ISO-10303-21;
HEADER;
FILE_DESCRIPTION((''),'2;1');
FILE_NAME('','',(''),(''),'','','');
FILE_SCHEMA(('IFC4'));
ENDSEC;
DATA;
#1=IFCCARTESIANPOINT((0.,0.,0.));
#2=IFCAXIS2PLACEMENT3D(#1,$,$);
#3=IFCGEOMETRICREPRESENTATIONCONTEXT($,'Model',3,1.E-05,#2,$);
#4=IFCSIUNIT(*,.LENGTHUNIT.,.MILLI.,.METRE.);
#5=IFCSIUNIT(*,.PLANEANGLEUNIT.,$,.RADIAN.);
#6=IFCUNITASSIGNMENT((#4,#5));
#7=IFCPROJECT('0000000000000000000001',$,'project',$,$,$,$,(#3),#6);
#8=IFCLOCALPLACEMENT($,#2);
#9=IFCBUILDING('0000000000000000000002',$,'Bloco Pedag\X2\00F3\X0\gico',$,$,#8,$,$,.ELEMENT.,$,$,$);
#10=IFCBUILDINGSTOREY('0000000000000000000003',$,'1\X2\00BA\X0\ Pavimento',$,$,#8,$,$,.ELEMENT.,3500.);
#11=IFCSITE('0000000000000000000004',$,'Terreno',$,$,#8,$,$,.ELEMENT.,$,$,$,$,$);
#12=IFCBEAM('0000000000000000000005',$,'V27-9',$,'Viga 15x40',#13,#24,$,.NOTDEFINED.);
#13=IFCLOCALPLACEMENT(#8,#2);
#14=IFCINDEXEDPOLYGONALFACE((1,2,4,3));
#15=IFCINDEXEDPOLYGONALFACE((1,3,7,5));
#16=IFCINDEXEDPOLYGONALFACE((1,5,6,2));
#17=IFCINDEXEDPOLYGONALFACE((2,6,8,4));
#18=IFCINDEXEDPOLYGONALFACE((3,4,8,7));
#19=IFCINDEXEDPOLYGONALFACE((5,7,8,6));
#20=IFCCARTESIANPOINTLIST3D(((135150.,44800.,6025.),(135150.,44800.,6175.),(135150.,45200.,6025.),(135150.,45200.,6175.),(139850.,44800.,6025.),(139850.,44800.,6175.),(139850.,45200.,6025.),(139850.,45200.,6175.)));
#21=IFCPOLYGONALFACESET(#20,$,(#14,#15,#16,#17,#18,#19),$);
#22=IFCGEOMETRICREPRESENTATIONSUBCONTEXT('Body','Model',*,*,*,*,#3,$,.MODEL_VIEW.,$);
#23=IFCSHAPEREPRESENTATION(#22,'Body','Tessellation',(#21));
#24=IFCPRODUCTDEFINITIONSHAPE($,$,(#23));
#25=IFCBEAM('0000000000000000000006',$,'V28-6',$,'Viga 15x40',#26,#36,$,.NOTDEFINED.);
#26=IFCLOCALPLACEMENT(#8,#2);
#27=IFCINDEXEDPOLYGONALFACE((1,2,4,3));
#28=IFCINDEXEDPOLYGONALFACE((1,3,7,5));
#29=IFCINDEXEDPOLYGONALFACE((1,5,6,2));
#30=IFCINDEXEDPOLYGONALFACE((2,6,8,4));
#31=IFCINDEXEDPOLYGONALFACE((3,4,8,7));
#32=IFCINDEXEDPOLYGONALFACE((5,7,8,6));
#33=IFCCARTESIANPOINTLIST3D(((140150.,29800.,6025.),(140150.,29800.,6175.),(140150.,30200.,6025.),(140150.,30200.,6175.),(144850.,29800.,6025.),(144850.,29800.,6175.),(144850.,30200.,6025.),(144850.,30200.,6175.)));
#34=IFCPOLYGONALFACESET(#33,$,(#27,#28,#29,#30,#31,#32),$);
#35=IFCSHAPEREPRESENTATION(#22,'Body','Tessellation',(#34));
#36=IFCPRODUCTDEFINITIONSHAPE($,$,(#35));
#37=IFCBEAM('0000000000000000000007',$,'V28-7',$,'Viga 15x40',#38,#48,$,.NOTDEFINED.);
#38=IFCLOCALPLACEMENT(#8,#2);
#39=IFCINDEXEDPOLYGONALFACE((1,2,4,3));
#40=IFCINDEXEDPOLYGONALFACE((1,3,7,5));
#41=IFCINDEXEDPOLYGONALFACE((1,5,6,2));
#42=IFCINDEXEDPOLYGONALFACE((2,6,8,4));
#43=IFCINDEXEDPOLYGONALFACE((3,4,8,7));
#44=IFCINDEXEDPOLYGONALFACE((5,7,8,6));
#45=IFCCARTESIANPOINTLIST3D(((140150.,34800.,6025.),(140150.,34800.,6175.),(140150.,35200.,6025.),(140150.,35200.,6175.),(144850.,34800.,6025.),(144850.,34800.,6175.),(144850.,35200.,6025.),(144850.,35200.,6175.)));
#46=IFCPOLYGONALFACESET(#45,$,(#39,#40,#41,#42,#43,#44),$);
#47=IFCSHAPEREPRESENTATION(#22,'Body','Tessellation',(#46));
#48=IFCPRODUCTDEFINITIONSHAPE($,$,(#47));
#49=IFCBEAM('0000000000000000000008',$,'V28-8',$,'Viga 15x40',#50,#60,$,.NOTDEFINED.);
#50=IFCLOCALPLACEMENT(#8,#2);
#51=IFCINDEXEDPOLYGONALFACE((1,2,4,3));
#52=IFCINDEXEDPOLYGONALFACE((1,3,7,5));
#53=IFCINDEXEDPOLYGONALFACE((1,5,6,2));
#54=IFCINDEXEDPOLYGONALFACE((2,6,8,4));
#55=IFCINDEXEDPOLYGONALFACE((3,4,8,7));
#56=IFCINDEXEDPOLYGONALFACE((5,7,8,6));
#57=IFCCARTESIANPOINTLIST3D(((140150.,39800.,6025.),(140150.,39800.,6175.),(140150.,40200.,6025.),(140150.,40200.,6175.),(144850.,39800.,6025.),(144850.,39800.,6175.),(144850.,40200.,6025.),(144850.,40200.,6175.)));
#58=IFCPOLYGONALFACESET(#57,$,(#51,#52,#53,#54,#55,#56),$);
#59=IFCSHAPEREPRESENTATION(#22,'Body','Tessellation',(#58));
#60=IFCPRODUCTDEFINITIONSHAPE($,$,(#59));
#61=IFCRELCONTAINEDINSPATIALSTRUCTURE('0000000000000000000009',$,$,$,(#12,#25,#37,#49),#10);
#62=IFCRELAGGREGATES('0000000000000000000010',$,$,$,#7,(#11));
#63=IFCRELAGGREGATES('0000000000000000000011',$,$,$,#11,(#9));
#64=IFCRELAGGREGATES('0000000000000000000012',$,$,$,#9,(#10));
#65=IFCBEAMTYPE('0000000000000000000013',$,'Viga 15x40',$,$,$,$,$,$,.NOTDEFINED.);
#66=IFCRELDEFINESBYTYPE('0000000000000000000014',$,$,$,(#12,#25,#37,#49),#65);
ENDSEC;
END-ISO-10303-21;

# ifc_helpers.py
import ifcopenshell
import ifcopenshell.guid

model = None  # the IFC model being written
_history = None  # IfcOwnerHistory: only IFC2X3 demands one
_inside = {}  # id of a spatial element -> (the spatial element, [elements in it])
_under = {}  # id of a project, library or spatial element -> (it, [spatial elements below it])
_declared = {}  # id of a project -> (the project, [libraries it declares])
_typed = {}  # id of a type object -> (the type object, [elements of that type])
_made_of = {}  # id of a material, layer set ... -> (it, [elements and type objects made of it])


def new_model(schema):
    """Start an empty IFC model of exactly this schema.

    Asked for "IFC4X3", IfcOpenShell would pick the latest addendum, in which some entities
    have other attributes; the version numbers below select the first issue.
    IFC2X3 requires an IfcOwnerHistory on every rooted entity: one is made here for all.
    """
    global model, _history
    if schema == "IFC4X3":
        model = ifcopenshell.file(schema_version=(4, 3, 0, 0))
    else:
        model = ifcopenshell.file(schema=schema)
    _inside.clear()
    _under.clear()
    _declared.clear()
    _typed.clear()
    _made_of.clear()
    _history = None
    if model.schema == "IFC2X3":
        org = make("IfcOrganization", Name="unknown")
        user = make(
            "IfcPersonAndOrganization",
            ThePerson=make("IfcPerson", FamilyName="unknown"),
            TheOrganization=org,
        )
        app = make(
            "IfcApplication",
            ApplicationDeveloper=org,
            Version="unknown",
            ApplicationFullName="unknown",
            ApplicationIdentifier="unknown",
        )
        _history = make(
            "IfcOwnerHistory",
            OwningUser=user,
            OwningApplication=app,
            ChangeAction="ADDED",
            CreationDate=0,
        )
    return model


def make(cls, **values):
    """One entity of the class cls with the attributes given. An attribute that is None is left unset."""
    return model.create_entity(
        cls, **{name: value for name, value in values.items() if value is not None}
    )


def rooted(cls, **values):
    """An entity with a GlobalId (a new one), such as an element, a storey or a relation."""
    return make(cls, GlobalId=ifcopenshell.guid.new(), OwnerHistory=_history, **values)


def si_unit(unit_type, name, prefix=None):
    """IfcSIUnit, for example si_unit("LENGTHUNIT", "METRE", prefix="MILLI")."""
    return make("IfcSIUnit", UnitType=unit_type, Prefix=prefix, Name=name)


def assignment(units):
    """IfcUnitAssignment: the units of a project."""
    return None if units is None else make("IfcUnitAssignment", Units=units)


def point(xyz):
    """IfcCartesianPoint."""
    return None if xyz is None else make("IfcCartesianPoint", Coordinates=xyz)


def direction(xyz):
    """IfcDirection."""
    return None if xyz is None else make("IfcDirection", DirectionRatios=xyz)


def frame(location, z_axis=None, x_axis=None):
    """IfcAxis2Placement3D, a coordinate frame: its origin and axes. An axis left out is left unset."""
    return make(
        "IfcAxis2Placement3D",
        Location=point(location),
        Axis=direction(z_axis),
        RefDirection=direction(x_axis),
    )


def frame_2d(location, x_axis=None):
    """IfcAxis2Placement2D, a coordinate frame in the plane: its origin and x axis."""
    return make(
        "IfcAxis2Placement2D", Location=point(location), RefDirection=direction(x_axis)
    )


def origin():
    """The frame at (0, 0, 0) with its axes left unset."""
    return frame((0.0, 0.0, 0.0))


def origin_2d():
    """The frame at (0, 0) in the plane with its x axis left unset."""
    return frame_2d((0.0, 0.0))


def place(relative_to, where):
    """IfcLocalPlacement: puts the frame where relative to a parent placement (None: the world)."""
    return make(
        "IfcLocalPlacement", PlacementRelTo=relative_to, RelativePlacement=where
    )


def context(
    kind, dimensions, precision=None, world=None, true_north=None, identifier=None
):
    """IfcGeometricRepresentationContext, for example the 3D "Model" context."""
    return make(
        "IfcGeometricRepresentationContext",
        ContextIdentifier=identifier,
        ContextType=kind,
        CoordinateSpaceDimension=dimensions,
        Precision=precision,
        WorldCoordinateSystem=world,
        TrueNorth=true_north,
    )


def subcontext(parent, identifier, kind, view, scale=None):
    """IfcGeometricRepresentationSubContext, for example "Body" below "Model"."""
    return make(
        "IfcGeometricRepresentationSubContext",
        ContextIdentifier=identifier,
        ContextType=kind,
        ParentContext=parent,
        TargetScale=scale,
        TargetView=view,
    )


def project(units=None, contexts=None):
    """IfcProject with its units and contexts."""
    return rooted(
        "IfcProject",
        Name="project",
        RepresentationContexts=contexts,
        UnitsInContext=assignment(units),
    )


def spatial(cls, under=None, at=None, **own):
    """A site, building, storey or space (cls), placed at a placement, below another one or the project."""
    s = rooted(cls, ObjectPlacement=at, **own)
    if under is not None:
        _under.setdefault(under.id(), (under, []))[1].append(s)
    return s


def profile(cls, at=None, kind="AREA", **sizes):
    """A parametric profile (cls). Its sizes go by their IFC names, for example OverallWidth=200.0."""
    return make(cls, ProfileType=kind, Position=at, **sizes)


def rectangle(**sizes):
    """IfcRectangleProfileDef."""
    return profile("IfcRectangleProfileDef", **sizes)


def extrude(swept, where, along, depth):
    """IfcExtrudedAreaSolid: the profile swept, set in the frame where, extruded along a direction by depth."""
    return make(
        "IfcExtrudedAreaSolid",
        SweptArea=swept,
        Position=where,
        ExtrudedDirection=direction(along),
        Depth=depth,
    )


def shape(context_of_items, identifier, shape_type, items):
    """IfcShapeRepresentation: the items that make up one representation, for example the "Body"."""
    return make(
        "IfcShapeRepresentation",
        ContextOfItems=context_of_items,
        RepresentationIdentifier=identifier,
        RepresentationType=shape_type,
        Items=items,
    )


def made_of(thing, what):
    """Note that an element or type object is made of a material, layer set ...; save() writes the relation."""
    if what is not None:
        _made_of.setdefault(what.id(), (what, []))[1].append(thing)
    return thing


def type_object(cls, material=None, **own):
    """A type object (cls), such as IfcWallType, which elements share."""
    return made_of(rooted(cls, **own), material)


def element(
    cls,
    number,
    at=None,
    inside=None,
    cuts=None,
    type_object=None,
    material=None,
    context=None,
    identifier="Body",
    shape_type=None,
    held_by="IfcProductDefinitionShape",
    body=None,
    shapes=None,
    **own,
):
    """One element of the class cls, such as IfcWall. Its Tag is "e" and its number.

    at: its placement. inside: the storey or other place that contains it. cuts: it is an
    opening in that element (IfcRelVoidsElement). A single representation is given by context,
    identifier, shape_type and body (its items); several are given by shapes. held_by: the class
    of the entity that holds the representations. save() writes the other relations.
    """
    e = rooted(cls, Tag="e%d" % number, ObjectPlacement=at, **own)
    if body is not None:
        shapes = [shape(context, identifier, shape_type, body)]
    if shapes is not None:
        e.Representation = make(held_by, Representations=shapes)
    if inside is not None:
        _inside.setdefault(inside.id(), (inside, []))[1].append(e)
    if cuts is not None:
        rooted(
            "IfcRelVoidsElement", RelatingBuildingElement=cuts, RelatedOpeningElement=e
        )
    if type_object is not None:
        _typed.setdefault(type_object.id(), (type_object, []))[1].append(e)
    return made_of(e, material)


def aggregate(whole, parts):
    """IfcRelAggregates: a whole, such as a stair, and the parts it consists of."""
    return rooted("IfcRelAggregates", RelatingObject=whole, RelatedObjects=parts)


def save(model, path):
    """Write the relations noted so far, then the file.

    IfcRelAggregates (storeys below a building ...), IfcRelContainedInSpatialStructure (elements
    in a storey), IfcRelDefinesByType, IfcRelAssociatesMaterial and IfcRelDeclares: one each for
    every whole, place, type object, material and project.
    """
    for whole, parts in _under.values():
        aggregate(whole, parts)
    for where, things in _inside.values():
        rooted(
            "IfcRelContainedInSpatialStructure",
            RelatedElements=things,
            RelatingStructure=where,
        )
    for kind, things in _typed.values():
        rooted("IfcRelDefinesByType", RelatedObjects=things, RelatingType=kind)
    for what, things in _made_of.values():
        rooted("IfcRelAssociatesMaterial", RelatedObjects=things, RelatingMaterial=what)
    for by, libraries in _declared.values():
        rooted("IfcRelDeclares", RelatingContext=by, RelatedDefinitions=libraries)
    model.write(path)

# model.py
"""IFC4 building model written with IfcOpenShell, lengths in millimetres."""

from ifc_helpers import new_model, si_unit, frame, origin, origin_2d, place, context, subcontext, project, spatial, rectangle, extrude, type_object, element, save


model = new_model("IFC4")

# Units and contexts
model_context = context("Model", 3, precision=1e-05, world=origin())
body_context = subcontext(model_context, "Body", "Model", "MODEL_VIEW")
ifc_project = project(units=[si_unit("LENGTHUNIT", "METRE", prefix="MILLI"), si_unit("PLANEANGLEUNIT", "RADIAN")], contexts=[model_context])

# Site, building, storey
placement = place(None, origin())
site = spatial("IfcSite", under=ifc_project, at=placement, Name="Terreno", CompositionType="ELEMENT")
building = spatial("IfcBuilding", under=site, at=placement, Name="Bloco Pedagógico", CompositionType="ELEMENT")
storey = spatial("IfcBuildingStorey", under=building, at=placement, Name="1º Pavimento", CompositionType="ELEMENT", Elevation=3500.0)

# Beams
beam_type = type_object("IfcBeamType", Name="Viga 15x40", PredefinedType="NOTDEFINED")
for number, where, z_axis, x_axis, name in (
    (1, (135150.0, 45000.0, 6100.0), (1.0, 0.0, 0.0), (0.0, 1.0, 0.0), "V27-9"),
    (2, (140150.0, 30000.0, 6100.0), (1.0, 0.0, 0.0), (0.0, 1.0, 0.0), "V28-6"),
    (3, (140150.0, 35000.0, 6100.0), (1.0, 0.0, 0.0), (0.0, 1.0, 0.0), "V28-7"),
    (4, (140150.0, 40000.0, 6100.0), (1.0, 0.0, 0.0), (0.0, 1.0, 0.0), "V28-8"),
):
    element("IfcBeam", number, at=place(None, frame(where, z_axis=z_axis, x_axis=x_axis)), inside=storey, type_object=beam_type, Name=name, ObjectType="Viga 15x40", PredefinedType="NOTDEFINED", context=body_context, shape_type="SweptSolid", body=[
        extrude(rectangle(XDim=400.0, YDim=150.0, at=origin_2d()), None, (0.0, 0.0, 1.0), 4700.0),
    ])

save(model, "model.ifc")
